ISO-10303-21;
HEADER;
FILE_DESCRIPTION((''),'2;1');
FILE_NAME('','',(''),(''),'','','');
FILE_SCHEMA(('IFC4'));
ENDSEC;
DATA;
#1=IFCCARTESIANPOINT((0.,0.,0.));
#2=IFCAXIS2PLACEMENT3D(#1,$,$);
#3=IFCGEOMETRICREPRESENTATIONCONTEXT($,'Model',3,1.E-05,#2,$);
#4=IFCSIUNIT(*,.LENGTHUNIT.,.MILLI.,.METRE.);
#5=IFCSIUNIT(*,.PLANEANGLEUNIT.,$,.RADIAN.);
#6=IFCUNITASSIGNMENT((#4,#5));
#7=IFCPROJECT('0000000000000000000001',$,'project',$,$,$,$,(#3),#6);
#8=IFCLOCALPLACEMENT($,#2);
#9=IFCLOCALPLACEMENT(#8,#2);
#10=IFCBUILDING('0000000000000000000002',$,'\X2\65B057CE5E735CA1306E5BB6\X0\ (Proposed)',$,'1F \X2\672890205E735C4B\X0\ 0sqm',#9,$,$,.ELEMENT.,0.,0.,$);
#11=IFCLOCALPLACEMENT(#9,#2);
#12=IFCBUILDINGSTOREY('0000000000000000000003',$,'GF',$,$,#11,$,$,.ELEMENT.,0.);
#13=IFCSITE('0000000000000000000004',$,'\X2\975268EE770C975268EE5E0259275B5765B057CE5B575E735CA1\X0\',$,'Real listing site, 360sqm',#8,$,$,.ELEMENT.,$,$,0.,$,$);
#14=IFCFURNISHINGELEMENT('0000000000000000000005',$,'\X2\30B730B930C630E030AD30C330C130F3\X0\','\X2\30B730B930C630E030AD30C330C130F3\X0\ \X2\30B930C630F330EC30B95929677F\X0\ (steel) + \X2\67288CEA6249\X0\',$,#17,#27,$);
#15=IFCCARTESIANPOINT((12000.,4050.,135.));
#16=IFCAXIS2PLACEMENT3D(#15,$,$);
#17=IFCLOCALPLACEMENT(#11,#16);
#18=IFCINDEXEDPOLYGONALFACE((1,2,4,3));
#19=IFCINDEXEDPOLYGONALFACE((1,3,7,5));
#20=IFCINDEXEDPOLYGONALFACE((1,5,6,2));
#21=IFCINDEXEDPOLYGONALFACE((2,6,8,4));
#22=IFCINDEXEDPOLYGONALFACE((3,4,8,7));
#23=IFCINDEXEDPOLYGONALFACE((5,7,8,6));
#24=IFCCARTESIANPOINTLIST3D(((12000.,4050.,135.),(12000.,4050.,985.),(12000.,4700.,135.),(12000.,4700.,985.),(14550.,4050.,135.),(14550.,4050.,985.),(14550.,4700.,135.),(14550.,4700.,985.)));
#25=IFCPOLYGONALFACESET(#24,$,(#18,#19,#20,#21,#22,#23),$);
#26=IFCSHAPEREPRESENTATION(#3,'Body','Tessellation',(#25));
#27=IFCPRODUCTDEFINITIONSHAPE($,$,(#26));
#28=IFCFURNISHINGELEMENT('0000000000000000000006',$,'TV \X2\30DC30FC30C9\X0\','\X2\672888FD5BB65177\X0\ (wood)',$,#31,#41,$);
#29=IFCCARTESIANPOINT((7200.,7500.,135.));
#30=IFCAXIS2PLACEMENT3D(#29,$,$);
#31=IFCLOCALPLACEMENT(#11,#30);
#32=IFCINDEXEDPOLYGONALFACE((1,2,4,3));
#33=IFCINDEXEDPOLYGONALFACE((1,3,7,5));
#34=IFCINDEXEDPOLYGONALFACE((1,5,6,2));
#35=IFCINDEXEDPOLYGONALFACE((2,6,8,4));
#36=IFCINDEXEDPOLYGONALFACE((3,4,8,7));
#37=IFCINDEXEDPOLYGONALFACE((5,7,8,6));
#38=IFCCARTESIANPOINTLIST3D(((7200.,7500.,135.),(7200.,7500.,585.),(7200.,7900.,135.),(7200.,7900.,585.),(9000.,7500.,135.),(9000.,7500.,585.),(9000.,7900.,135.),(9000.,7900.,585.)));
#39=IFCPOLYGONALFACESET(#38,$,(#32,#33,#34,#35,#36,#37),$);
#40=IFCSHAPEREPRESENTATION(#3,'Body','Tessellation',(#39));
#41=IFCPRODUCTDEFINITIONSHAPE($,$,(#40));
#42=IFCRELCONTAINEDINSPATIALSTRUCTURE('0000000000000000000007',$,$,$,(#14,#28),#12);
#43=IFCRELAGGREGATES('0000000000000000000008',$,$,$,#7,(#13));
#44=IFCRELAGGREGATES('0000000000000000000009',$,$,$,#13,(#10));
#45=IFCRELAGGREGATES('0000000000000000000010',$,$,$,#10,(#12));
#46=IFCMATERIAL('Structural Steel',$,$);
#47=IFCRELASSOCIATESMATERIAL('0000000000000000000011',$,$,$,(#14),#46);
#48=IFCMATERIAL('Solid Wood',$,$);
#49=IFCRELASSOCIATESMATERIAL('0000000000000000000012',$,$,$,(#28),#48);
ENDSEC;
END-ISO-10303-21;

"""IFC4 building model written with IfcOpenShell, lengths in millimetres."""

from ifc_helpers import new_model, si_unit, frame, frame_2d, origin, place, context, project, spatial, rectangle, extrude, material, element, save


model = new_model("IFC4")

# Units and contexts
model_context = context("Model", 3, precision=1e-05, world=origin())
ifc_project = project(units=[si_unit("LENGTHUNIT", "METRE", prefix="MILLI"), si_unit("PLANEANGLEUNIT", "RADIAN")], contexts=[model_context])

# Site, building, storey
site_placement = place(None, origin())
site = spatial("IfcSite", under=ifc_project, at=site_placement, Name="青森県青森市大字新城字平岡", ObjectType="Real listing site, 360sqm", CompositionType="ELEMENT", RefElevation=0.0)
building_placement = place(site_placement, origin())
building = spatial("IfcBuilding", under=site, at=building_placement, Name="新城平岡の家 (Proposed)", ObjectType="1F 木造平屋 0sqm", CompositionType="ELEMENT", ElevationOfRefHeight=0.0, ElevationOfTerrain=0.0)
storey_placement = place(building_placement, origin())
storey = spatial("IfcBuildingStorey", under=building, at=storey_placement, Name="GF", CompositionType="ELEMENT", Elevation=0.0)

# Shared definitions
ifc_material_1 = material(Name="Solid Wood")

# Furnishing elements
ifc_material_2 = material(Name="Structural Steel")
furnishing_1_placement = place(storey_placement, frame((12000.0, 4050.0, 135.0)))
element("IfcFurnishingElement", 1, at=furnishing_1_placement, inside=storey, material=ifc_material_2, Name="システムキッチン", Description="システムキッチン ステンレス天板 (steel) + 木質扉", context=model_context, shape_type="SweptSolid", body=[
    extrude(rectangle(XDim=2550.0, YDim=650.0, at=frame_2d((1275.0, 325.0))), frame((12000.0, 4050.0, 135.0)), (0.0, 0.0, 1.0), 850.0),
])
furnishing_2_placement = place(storey_placement, frame((7200.0, 7500.0, 135.0)))
element("IfcFurnishingElement", 2, at=furnishing_2_placement, inside=storey, material=ifc_material_1, Name="TV ボード", Description="木製家具 (wood)", context=model_context, shape_type="SweptSolid", body=[
    extrude(rectangle(XDim=1800.0, YDim=400.0, at=frame_2d((900.0, 200.0))), frame((7200.0, 7500.0, 135.0)), (0.0, 0.0, 1.0), 450.0),
])

save(model, "model.ifc")
